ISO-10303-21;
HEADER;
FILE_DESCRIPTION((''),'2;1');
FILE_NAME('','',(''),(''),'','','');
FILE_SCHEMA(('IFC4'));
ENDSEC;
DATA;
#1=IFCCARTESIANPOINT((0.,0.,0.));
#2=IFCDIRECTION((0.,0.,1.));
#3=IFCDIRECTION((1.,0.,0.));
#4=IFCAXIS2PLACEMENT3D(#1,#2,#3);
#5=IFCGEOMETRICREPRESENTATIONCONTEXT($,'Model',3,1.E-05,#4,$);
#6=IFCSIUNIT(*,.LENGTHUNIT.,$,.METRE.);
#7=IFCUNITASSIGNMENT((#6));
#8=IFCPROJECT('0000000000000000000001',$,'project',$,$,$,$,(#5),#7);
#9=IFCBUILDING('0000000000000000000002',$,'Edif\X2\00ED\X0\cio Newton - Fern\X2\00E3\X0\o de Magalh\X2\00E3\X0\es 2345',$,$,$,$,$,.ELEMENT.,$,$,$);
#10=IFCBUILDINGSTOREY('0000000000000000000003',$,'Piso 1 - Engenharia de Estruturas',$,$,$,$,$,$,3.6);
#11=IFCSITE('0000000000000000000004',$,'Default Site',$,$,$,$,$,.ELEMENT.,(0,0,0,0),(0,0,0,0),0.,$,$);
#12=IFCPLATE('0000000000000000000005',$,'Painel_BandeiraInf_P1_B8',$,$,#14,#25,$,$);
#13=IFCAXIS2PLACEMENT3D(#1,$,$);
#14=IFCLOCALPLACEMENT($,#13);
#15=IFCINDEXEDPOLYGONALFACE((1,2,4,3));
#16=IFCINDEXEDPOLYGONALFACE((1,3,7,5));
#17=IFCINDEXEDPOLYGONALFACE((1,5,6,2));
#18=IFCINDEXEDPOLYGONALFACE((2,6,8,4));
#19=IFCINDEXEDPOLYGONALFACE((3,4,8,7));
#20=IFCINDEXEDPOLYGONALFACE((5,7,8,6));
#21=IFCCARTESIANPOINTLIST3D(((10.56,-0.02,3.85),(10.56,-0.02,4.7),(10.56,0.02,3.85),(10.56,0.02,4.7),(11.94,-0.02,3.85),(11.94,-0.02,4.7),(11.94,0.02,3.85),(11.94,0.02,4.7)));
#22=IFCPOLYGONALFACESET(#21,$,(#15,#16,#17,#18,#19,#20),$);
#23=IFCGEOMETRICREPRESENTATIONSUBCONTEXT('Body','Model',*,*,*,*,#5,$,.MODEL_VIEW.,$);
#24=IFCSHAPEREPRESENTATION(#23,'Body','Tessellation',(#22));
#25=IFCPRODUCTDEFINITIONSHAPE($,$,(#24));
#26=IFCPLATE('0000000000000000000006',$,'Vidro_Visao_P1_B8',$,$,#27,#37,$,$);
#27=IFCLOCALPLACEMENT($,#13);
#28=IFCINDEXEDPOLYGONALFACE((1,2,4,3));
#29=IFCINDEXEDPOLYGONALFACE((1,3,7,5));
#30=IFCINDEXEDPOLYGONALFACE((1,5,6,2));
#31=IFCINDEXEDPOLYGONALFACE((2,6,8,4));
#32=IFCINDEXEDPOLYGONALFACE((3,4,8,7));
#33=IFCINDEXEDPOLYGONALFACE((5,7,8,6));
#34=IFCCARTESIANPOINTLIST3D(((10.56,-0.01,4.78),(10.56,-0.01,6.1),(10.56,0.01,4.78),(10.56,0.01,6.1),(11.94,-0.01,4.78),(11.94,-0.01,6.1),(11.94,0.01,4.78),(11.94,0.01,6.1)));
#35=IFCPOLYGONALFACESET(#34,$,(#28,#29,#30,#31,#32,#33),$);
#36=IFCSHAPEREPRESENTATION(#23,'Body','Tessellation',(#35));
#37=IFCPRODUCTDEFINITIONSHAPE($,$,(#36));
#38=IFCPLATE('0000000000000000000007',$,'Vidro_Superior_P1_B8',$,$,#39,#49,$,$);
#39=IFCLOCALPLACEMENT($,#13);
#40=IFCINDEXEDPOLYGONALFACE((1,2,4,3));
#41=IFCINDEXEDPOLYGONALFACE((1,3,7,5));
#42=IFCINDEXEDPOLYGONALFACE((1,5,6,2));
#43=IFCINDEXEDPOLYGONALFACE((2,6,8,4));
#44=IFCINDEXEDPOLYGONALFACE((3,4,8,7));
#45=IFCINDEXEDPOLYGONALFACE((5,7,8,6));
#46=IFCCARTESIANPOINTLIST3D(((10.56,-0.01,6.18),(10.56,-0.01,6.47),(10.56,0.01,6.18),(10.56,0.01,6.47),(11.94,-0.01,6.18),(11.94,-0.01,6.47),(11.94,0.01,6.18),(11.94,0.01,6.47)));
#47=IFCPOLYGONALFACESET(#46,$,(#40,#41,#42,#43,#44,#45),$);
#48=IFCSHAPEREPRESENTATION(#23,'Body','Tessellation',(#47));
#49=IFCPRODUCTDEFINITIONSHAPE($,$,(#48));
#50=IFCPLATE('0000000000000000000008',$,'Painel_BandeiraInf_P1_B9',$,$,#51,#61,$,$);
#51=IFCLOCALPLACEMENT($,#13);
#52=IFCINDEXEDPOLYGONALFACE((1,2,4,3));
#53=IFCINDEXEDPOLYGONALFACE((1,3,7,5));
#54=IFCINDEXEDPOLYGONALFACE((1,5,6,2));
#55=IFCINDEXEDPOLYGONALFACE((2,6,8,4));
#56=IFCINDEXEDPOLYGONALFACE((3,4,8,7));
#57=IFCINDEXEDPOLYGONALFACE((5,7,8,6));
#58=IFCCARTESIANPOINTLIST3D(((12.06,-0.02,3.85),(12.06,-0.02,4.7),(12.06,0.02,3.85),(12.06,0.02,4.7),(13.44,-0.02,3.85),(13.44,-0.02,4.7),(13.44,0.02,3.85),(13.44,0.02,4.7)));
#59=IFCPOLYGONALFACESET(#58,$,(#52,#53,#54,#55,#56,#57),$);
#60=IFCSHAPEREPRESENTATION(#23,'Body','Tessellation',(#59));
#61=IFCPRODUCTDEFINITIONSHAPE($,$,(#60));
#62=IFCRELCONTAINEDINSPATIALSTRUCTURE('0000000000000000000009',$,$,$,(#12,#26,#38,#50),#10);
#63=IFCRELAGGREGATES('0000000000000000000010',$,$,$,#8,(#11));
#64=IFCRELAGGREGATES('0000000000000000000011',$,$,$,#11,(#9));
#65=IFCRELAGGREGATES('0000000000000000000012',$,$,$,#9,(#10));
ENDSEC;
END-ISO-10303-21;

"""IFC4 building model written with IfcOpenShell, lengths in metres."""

from ifc_helpers import new_model, si_unit, frame, frame_2d, origin_with_axes, place, context, subcontext, project, spatial, rectangle, extrude, element, save


model = new_model("IFC4")

# Units and contexts
model_context = context("Model", 3, precision=1e-05, world=origin_with_axes())
body_context = subcontext(model_context, "Body", "Model", "MODEL_VIEW")
ifc_project = project(units=[si_unit("LENGTHUNIT", "METRE")], contexts=[model_context])

# Site, building, storey
site = spatial("IfcSite", under=ifc_project, Name="Default Site", CompositionType="ELEMENT", RefLatitude=(0, 0, 0, 0), RefLongitude=(0, 0, 0, 0), RefElevation=0.0)
building = spatial("IfcBuilding", under=site, Name="Edifício Newton - Fernão de Magalhães 2345", CompositionType="ELEMENT")
storey = spatial("IfcBuildingStorey", under=building, Name="Piso 1 - Engenharia de Estruturas", Elevation=3.6)

# Plates
plate_1_placement = place(None, frame((10.56, -0.02, 3.85), z_axis=(0.0, 0.0, 1.0), x_axis=(1.0, 0.0, 0.0)))
element("IfcPlate", 1, at=plate_1_placement, inside=storey, Name="Painel_BandeiraInf_P1_B8", context=body_context, shape_type="SweptSolid", body=[
    extrude(rectangle(XDim=1.38, YDim=0.04, at=frame_2d((0.69, 0.02))), origin_with_axes(), (0.0, 0.0, 1.0), 0.85),
])
plate_2_placement = place(None, frame((10.56, -0.01, 4.78), z_axis=(0.0, 0.0, 1.0), x_axis=(1.0, 0.0, 0.0)))
element("IfcPlate", 2, at=plate_2_placement, inside=storey, Name="Vidro_Visao_P1_B8", context=body_context, shape_type="SweptSolid", body=[
    extrude(rectangle(XDim=1.38, YDim=0.02, at=frame_2d((0.69, 0.01))), origin_with_axes(), (0.0, 0.0, 1.0), 1.32),
])
plate_3_placement = place(None, frame((10.56, -0.01, 6.18), z_axis=(0.0, 0.0, 1.0), x_axis=(1.0, 0.0, 0.0)))
element("IfcPlate", 3, at=plate_3_placement, inside=storey, Name="Vidro_Superior_P1_B8", context=body_context, shape_type="SweptSolid", body=[
    extrude(rectangle(XDim=1.38, YDim=0.02, at=frame_2d((0.69, 0.01))), origin_with_axes(), (0.0, 0.0, 1.0), 0.29),
])
plate_4_placement = place(None, frame((12.06, -0.02, 3.85), z_axis=(0.0, 0.0, 1.0), x_axis=(1.0, 0.0, 0.0)))
element("IfcPlate", 4, at=plate_4_placement, inside=storey, Name="Painel_BandeiraInf_P1_B9", context=body_context, shape_type="SweptSolid", body=[
    extrude(rectangle(XDim=1.38, YDim=0.04, at=frame_2d((0.69, 0.02))), origin_with_axes(), (0.0, 0.0, 1.0), 0.85),
])

save(model, "model.ifc")
